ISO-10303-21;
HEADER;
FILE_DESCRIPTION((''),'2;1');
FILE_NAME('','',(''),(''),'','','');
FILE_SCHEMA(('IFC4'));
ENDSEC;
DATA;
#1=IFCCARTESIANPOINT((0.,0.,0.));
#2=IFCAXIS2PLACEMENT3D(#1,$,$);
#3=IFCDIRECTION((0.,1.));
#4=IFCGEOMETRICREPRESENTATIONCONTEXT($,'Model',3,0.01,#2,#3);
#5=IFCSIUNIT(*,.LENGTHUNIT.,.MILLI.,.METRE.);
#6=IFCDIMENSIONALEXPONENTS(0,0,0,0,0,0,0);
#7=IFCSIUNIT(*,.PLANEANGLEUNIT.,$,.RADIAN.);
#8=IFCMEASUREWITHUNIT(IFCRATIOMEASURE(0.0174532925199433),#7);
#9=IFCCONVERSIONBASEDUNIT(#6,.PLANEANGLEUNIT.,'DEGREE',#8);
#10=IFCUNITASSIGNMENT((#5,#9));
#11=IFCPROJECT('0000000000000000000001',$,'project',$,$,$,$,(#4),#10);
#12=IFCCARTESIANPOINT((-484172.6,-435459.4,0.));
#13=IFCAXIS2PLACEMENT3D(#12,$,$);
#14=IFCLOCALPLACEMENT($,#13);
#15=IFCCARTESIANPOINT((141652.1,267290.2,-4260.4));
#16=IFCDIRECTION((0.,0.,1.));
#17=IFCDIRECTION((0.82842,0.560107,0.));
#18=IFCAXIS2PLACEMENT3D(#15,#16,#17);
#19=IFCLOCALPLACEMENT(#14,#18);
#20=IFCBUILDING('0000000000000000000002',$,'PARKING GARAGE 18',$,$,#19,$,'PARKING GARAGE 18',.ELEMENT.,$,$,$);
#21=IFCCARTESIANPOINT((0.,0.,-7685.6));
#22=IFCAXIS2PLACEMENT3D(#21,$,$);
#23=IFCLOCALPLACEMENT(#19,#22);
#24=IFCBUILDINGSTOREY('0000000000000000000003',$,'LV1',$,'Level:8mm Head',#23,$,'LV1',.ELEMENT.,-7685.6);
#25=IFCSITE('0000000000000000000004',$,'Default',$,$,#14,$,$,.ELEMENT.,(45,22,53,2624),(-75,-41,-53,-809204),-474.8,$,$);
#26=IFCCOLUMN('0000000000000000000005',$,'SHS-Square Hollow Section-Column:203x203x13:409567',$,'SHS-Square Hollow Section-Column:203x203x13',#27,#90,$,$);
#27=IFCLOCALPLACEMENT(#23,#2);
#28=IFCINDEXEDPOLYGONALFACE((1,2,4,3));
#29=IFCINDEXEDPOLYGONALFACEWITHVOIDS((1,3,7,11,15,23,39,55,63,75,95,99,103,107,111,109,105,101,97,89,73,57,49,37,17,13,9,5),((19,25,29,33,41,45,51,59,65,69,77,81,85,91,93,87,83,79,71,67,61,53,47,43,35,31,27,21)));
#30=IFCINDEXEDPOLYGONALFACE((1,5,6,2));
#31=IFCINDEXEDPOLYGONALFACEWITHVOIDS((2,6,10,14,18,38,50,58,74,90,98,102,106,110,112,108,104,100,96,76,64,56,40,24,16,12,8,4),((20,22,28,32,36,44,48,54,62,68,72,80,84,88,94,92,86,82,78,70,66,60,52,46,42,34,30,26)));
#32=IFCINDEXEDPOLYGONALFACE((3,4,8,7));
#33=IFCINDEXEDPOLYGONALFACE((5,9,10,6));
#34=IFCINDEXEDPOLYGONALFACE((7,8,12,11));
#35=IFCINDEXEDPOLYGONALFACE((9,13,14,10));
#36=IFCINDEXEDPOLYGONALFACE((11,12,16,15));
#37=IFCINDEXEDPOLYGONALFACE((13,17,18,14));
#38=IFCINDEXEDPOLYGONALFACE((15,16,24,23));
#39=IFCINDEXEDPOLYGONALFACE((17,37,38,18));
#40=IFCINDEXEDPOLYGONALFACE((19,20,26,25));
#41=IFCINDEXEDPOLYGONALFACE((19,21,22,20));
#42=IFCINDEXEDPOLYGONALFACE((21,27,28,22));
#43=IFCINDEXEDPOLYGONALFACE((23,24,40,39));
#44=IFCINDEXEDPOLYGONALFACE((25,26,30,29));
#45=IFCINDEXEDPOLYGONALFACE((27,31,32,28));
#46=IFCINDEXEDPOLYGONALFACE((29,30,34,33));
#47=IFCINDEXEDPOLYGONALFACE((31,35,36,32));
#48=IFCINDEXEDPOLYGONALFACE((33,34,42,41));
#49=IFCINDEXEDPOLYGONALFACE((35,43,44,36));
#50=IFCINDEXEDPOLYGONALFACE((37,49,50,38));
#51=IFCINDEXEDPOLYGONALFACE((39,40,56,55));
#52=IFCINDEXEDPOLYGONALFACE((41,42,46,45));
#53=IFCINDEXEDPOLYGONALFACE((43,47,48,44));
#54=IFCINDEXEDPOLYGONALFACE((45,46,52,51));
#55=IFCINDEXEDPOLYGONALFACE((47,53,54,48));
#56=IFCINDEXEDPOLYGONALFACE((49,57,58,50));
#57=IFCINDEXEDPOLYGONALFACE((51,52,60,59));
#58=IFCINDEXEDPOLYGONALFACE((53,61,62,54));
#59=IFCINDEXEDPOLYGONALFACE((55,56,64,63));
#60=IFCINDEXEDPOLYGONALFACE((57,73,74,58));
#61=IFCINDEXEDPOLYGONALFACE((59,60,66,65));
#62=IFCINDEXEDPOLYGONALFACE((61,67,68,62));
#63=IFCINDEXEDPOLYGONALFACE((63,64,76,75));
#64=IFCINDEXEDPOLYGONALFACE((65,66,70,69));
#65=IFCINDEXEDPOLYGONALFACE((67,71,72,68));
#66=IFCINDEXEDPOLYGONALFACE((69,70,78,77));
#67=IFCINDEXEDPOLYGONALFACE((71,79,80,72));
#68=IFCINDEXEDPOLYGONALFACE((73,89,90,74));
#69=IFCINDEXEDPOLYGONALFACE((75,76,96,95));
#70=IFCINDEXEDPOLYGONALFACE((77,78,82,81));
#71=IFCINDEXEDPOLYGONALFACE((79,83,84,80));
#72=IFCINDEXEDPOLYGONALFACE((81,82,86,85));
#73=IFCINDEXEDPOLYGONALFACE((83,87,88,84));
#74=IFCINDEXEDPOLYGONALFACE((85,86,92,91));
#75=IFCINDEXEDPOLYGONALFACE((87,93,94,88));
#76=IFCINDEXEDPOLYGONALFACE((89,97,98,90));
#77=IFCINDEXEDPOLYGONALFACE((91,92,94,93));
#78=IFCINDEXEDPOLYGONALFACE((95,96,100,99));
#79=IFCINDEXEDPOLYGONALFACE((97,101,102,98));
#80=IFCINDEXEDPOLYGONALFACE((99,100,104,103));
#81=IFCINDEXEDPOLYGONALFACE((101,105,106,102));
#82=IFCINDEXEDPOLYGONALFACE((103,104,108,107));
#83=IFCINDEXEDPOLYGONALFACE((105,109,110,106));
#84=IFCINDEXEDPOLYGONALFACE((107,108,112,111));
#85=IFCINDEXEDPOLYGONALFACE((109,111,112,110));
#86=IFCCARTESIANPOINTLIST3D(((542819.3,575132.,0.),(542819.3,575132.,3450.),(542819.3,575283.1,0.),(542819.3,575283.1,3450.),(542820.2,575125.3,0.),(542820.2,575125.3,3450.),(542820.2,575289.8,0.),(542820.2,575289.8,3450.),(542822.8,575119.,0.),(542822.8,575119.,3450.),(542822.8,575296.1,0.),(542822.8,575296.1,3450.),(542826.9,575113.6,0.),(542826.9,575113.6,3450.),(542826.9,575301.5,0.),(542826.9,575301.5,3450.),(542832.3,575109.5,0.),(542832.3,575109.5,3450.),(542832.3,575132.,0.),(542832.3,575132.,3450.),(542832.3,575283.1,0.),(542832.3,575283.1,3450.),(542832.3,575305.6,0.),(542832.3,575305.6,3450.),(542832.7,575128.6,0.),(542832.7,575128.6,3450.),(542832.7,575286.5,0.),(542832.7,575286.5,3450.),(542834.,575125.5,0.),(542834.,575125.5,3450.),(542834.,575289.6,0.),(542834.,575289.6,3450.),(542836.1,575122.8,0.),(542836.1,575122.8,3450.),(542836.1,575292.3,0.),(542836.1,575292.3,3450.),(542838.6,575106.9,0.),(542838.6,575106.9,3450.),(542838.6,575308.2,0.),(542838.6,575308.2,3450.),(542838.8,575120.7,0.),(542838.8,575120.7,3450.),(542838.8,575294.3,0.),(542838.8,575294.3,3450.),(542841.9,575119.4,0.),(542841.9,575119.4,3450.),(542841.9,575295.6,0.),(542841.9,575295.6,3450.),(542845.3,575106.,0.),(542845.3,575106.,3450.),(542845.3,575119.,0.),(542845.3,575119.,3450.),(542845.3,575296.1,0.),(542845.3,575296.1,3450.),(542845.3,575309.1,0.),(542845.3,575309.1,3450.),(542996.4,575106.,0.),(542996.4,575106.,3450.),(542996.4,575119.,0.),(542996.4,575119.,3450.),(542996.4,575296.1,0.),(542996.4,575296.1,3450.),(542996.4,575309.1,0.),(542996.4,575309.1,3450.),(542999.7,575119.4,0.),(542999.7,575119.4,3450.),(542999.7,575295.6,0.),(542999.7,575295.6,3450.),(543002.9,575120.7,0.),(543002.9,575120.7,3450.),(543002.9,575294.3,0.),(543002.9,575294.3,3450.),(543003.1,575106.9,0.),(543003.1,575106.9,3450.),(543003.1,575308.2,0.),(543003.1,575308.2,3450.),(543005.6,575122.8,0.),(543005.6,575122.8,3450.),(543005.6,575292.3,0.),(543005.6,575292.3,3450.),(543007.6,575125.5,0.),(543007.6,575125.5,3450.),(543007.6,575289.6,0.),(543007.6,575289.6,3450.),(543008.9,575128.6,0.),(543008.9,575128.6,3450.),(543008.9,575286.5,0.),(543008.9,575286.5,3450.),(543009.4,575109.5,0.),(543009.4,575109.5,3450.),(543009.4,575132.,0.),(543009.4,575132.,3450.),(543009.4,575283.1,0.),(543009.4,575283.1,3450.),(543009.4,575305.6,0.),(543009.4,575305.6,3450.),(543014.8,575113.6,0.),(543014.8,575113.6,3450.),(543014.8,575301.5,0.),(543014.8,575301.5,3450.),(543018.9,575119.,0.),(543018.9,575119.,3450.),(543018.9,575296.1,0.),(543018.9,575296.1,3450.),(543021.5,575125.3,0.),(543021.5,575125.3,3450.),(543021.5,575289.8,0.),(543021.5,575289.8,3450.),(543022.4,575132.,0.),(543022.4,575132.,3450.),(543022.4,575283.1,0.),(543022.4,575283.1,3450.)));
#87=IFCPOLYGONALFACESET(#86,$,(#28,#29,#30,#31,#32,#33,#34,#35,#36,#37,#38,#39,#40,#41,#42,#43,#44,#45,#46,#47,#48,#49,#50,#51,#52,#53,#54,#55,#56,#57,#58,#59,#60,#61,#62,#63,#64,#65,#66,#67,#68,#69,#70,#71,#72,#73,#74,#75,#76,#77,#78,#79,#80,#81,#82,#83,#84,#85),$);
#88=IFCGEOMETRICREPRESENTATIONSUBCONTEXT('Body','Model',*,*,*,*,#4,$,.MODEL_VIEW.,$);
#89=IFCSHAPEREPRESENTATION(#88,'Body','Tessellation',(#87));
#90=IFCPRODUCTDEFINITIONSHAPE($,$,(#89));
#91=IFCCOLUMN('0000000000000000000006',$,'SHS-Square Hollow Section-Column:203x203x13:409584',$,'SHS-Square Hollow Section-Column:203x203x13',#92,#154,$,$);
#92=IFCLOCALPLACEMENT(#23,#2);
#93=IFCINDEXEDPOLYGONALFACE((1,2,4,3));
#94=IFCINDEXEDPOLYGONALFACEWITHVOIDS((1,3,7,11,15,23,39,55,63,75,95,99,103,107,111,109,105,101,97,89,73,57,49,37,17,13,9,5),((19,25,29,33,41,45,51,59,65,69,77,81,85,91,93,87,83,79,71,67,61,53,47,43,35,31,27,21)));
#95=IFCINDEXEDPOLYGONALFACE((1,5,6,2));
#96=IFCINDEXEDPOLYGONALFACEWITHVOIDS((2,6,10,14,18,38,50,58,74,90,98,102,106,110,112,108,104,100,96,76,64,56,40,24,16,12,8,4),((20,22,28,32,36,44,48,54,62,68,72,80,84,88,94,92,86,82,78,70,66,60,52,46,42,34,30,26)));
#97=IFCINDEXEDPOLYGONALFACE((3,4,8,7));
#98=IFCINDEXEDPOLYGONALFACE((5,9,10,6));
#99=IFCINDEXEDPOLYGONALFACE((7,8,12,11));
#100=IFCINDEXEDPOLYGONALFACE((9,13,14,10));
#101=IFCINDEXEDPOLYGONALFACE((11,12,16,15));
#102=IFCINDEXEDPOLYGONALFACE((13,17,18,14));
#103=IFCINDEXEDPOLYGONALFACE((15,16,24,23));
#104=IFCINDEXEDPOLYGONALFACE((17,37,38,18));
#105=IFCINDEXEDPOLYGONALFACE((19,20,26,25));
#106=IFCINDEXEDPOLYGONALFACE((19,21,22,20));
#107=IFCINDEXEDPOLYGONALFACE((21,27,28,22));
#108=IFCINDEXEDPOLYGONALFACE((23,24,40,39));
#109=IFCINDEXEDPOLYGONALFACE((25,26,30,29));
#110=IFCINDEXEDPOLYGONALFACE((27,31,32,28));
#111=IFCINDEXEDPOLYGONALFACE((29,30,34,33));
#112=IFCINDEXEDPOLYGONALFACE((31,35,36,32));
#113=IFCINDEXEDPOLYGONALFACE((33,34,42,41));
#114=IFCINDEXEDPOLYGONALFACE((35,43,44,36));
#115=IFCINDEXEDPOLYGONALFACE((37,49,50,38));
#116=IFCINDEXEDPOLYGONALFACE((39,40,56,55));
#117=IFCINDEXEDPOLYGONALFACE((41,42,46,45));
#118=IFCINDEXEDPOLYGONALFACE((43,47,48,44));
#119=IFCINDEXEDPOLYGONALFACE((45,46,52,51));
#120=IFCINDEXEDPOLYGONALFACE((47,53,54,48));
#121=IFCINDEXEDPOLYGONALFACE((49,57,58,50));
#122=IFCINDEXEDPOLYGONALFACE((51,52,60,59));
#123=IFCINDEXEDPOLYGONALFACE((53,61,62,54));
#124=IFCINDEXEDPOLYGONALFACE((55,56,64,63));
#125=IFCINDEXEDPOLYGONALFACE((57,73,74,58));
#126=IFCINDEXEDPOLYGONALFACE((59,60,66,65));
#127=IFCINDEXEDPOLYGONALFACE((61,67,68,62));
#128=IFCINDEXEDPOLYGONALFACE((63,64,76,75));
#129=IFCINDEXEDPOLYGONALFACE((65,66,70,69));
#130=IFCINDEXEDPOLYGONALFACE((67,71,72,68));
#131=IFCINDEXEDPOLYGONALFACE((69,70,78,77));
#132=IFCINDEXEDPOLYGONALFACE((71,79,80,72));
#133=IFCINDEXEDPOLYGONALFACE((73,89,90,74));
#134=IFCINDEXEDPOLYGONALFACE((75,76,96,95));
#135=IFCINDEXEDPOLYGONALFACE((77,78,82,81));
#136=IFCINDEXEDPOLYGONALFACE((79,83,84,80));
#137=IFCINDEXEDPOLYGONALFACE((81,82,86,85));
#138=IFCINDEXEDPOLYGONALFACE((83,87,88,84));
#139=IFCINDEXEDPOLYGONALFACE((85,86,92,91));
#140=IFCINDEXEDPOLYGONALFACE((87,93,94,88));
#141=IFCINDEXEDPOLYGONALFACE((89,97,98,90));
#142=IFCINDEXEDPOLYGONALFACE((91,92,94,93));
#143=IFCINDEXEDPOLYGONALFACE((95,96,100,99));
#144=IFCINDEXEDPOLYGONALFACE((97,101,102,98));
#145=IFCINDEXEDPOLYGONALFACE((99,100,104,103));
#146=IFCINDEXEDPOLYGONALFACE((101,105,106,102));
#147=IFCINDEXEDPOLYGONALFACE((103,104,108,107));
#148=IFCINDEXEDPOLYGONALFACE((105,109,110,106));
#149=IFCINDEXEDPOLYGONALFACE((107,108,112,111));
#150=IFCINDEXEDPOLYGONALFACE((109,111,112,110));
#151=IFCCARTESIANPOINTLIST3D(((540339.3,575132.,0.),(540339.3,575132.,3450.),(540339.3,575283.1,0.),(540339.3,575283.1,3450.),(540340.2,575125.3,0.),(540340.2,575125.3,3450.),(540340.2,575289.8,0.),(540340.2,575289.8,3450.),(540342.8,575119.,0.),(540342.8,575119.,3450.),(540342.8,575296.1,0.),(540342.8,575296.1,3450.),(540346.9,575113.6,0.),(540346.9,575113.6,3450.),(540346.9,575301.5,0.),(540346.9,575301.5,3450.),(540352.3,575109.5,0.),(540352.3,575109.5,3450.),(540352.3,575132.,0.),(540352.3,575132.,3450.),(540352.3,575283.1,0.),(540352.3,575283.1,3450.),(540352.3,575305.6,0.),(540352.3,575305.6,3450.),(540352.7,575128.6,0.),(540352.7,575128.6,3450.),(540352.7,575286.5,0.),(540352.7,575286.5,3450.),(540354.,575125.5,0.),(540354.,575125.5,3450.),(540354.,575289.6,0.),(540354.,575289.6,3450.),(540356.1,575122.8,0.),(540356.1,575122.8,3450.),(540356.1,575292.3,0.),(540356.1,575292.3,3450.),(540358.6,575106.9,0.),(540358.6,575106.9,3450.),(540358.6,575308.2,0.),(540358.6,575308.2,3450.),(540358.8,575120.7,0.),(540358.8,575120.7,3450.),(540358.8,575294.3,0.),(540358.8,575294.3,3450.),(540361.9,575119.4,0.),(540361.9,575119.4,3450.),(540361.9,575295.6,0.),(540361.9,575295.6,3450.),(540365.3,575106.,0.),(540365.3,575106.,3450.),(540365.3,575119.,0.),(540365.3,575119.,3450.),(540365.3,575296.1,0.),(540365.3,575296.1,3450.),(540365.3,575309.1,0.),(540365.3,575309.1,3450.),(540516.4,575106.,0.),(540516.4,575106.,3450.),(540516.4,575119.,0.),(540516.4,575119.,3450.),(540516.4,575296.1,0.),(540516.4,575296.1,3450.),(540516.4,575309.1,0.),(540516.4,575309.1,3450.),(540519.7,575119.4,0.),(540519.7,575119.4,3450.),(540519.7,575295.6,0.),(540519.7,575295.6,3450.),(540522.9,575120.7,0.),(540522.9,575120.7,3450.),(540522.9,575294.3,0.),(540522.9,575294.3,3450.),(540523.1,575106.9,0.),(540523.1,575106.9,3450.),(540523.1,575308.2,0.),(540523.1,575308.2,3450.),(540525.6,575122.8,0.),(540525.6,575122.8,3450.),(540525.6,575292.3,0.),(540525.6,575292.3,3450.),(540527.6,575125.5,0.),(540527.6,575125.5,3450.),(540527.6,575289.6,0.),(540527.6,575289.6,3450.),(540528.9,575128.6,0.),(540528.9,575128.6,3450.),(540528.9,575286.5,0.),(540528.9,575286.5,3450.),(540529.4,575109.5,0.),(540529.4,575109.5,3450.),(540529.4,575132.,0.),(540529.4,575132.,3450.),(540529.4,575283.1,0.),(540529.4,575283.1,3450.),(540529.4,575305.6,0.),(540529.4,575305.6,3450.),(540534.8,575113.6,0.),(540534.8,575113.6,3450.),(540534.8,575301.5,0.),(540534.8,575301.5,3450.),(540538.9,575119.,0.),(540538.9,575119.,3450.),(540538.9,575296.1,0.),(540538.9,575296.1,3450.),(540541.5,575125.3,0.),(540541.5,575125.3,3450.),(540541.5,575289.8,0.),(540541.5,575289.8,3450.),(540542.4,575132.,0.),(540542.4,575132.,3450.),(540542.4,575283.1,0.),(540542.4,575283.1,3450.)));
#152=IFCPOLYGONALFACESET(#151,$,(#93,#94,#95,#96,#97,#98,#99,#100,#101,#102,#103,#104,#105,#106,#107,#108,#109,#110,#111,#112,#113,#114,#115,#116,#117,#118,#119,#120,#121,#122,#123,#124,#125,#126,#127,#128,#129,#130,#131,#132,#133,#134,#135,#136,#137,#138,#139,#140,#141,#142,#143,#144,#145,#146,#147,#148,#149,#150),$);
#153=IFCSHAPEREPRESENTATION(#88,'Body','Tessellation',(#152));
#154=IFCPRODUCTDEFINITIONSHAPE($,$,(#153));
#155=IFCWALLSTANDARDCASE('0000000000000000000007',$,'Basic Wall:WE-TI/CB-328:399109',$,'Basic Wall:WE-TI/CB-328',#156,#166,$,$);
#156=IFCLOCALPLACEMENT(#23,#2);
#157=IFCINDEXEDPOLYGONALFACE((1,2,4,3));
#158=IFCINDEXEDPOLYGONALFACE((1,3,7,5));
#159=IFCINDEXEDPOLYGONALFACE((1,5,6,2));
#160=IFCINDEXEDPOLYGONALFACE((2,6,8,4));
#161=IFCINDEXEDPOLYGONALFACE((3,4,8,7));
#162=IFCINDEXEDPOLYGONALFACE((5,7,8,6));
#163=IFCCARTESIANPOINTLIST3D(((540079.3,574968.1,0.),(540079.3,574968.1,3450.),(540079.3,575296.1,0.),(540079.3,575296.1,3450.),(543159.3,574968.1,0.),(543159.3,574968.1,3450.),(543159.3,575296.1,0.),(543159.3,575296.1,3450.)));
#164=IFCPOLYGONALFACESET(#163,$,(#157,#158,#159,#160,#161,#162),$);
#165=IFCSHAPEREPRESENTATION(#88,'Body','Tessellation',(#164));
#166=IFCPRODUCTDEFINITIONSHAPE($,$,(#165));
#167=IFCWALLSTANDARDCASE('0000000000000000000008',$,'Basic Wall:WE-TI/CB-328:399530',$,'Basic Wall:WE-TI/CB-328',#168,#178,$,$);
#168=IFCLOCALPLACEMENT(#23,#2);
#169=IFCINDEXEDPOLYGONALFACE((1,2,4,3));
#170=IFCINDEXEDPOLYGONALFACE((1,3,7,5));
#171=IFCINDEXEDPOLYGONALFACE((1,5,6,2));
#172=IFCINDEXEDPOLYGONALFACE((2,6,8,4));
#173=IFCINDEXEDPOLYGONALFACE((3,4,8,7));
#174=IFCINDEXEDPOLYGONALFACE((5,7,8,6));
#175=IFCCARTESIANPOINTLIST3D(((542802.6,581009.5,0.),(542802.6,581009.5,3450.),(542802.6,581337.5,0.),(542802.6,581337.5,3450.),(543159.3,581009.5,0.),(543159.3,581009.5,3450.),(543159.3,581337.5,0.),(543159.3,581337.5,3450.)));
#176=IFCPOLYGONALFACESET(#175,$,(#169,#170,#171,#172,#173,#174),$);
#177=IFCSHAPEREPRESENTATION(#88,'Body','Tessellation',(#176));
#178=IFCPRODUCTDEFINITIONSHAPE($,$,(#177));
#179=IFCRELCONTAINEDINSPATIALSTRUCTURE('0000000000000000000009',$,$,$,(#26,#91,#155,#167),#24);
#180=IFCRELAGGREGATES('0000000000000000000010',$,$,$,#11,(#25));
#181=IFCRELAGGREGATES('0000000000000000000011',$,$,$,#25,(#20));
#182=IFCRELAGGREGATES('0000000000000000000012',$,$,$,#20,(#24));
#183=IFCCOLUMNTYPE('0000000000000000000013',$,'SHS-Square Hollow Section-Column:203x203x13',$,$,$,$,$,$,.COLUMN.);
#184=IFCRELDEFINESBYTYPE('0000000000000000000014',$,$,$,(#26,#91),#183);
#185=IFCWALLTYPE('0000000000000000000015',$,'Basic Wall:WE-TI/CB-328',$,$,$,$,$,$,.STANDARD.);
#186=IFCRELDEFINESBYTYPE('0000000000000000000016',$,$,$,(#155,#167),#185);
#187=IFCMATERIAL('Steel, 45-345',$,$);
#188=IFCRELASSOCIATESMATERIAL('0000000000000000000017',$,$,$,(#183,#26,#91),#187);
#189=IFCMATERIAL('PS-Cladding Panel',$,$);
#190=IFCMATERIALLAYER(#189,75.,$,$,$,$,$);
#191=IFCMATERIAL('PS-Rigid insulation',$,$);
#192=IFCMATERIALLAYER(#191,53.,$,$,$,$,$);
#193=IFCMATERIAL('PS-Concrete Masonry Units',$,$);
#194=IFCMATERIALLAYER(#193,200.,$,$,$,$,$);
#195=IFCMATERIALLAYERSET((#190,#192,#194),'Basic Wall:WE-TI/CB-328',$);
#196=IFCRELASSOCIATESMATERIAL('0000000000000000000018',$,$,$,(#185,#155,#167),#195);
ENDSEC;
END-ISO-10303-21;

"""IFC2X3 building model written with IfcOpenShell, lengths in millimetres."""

from ifc_helpers import new_model, entity, si_unit, converted_unit, direction, frame, frame_2d, origin, place, context, subcontext, project, spatial, polyline, circle_curve, parameter, trimmed, segment, composite_curve, rectangle, outline, extrude, source, transform, mapped, material, layer, layer_set, layer_usage, type_object, type_shapes, element, save


model = new_model("IFC2X3")

# Units and contexts
model_context = context("Model", 3, precision=0.01, world=origin(), true_north=direction((0.0, 1.0)))
body_context = subcontext(model_context, "Body", "Model", "MODEL_VIEW")
ifc_project = project(units=[si_unit("LENGTHUNIT", "METRE", prefix="MILLI"), converted_unit("PLANEANGLEUNIT", "DEGREE", entity("IfcRatioMeasure", 0.0174532925199433), si_unit("PLANEANGLEUNIT", "RADIAN"), dimensions=[0, 0, 0, 0, 0, 0, 0])], contexts=[model_context])

# Site, building, storey
site_placement = place(None, frame((-484172.6, -435459.4, 0.0)))
site = spatial("IfcSite", under=ifc_project, at=site_placement, Name="Default", CompositionType="ELEMENT", RefLatitude=(45, 22, 53, 2624), RefLongitude=(-75, -41, -53, -809204), RefElevation=-474.8)
building_placement = place(site_placement, frame((141652.1, 267290.2, -4260.4), z_axis=(0.0, 0.0, 1.0), x_axis=(0.82842, 0.560107, 0.0)))
building = spatial("IfcBuilding", under=site, at=building_placement, Name="PARKING GARAGE 18", LongName="PARKING GARAGE 18", CompositionType="ELEMENT")
storey_placement = place(building_placement, frame((0.0, 0.0, -7685.6)))
storey = spatial("IfcBuildingStorey", under=building, at=storey_placement, Name="LV1", ObjectType="Level:8mm Head", LongName="LV1", CompositionType="ELEMENT", Elevation=-7685.6)

# Columns
ifc_material_1 = material(Name="Steel, 45-345")
column_type = type_object("IfcColumnType", Name="SHS-Square Hollow Section-Column:203x203x13", PredefinedType="COLUMN", material=ifc_material_1)
shared_shape_1 = source(origin(), body_context, "Body", "SweptSolid", [
    extrude(outline(composite_curve([segment(polyline([(-75.6, -101.5), (75.6, -101.5)]), True, "CONTINUOUS"), segment(trimmed(circle_curve(frame_2d((75.6, -75.6), x_axis=(-1.0, 0.0)), 26.0), [parameter(90.0)], [parameter(180.0)], True, "PARAMETER"), True, "CONTINUOUS"), segment(polyline([(101.5, -75.6), (101.5, 75.6)]), True, "CONTINUOUS"), segment(trimmed(circle_curve(frame_2d((75.5, 75.6), x_axis=(-1.0, 0.0)), 26.0), [parameter(180.0)], [parameter(270.0)], True, "PARAMETER"), True, "CONTINUOUS"), segment(polyline([(75.5, 101.6), (-75.5, 101.6)]), True, "CONTINUOUS"), segment(trimmed(circle_curve(frame_2d((-75.5, 75.5), x_axis=(-1.0, 0.0)), 26.0), [parameter(270.0)], [parameter(360.0)], True, "PARAMETER"), True, "CONTINUOUS"), segment(polyline([(-101.5, 75.5), (-101.5, -75.6)]), True, "CONTINUOUS"), segment(trimmed(circle_curve(frame_2d((-75.6, -75.6), x_axis=(-1.0, 0.0)), 26.0), [parameter(360.0)], [parameter(90.0)], True, "PARAMETER"), True, "CONTINUOUS")], self_intersect=False), holes=[composite_curve([segment(trimmed(circle_curve(frame_2d((-75.6, -75.6), x_axis=(-1.0, 0.0)), 13.0), [parameter(0.0)], [parameter(90.0)], True, "PARAMETER"), False, "CONTINUOUS"), segment(polyline([(-88.5, -75.6), (-88.5, 75.6)]), True, "CONTINUOUS"), segment(trimmed(circle_curve(frame_2d((-75.6, 75.6), x_axis=(-1.0, 0.0)), 13.0), [parameter(270.0)], [parameter(0.0)], True, "PARAMETER"), False, "CONTINUOUS"), segment(polyline([(-75.6, 88.6), (75.5, 88.6)]), True, "CONTINUOUS"), segment(trimmed(circle_curve(frame_2d((75.5, 75.5), x_axis=(-1.0, 0.0)), 13.0), [parameter(180.0)], [parameter(270.0)], True, "PARAMETER"), False, "CONTINUOUS"), segment(polyline([(88.6, 75.5), (88.6, -75.5)]), True, "CONTINUOUS"), segment(trimmed(circle_curve(frame_2d((75.6, -75.5), x_axis=(-1.0, 0.0)), 13.0), [parameter(90.0)], [parameter(180.0)], True, "PARAMETER"), False, "CONTINUOUS"), segment(polyline([(75.6, -88.5), (-75.6, -88.5)]), True, "CONTINUOUS")], self_intersect=False)]), frame((0.0, 0.0, -7685.6), z_axis=(0.0, 0.0, 1.0), x_axis=(-1.0, 0.0, 0.0)), (0.0, 0.0, 1.0), 3450.0),
])
type_shapes(column_type, [shared_shape_1])
for number, where, name in (
    (1, (542920.8, 575207.5, 7685.6), "SHS-Square Hollow Section-Column:203x203x13:409567"),
    (2, (540440.8, 575207.5, 7685.6), "SHS-Square Hollow Section-Column:203x203x13:409584"),
):
    element("IfcColumn", number, at=place(storey_placement, frame(where)), inside=storey, type_object=column_type, material=ifc_material_1, Name=name, ObjectType="SHS-Square Hollow Section-Column:203x203x13", context=body_context, shape_type="MappedRepresentation", body=[
        mapped(shared_shape_1, transform((0.0, 0.0, 0.0), scale=1.0)),
    ])

# Walls
ifc_material_2 = material(Name="PS-Cladding Panel")
ifc_layer_1 = layer(ifc_material_2, 75.0)
ifc_material_3 = material(Name="PS-Rigid insulation")
ifc_layer_2 = layer(ifc_material_3, 53.0)
ifc_material_4 = material(Name="PS-Concrete Masonry Units")
ifc_layer_3 = layer(ifc_material_4, 200.0)
ifc_layer_set_1 = layer_set([ifc_layer_1, ifc_layer_2, ifc_layer_3], Name="Basic Wall:WE-TI/CB-328")
ifc_layer_usage_1 = layer_usage(ifc_layer_set_1, "AXIS2", "NEGATIVE", 164.0)
wall_type_1 = type_object("IfcWallType", Name="Basic Wall:WE-TI/CB-328", PredefinedType="STANDARD", material=ifc_layer_set_1)
wall_1_placement = place(storey_placement, frame((543159.3, 575132.1, 0.0), z_axis=(0.0, 0.0, 1.0), x_axis=(-1.0, 0.0, 0.0)))
element("IfcWallStandardCase", 3, at=wall_1_placement, inside=storey, type_object=wall_type_1, material=ifc_layer_usage_1, Name="Basic Wall:WE-TI/CB-328:399109", ObjectType="Basic Wall:WE-TI/CB-328", context=body_context, shape_type="SweptSolid", body=[
    extrude(rectangle(XDim=3080.0, YDim=328.0, at=frame_2d((1540.0, 0.0), x_axis=(-1.0, 0.0))), origin(), (0.0, 0.0, 1.0), 3450.0),
])
ifc_layer_usage_2 = layer_usage(ifc_layer_set_1, "AXIS2", "NEGATIVE", 164.0)
wall_2_placement = place(storey_placement, frame((542802.6, 581173.5, 0.0)))
element("IfcWallStandardCase", 4, at=wall_2_placement, inside=storey, type_object=wall_type_1, material=ifc_layer_usage_2, Name="Basic Wall:WE-TI/CB-328:399530", ObjectType="Basic Wall:WE-TI/CB-328", context=body_context, shape_type="SweptSolid", body=[
    extrude(rectangle(XDim=356.7, YDim=328.0, at=frame_2d((178.3, 0.0), x_axis=(-1.0, 0.0))), origin(), (0.0, 0.0, 1.0), 3450.0),
])

save(model, "model.ifc")
